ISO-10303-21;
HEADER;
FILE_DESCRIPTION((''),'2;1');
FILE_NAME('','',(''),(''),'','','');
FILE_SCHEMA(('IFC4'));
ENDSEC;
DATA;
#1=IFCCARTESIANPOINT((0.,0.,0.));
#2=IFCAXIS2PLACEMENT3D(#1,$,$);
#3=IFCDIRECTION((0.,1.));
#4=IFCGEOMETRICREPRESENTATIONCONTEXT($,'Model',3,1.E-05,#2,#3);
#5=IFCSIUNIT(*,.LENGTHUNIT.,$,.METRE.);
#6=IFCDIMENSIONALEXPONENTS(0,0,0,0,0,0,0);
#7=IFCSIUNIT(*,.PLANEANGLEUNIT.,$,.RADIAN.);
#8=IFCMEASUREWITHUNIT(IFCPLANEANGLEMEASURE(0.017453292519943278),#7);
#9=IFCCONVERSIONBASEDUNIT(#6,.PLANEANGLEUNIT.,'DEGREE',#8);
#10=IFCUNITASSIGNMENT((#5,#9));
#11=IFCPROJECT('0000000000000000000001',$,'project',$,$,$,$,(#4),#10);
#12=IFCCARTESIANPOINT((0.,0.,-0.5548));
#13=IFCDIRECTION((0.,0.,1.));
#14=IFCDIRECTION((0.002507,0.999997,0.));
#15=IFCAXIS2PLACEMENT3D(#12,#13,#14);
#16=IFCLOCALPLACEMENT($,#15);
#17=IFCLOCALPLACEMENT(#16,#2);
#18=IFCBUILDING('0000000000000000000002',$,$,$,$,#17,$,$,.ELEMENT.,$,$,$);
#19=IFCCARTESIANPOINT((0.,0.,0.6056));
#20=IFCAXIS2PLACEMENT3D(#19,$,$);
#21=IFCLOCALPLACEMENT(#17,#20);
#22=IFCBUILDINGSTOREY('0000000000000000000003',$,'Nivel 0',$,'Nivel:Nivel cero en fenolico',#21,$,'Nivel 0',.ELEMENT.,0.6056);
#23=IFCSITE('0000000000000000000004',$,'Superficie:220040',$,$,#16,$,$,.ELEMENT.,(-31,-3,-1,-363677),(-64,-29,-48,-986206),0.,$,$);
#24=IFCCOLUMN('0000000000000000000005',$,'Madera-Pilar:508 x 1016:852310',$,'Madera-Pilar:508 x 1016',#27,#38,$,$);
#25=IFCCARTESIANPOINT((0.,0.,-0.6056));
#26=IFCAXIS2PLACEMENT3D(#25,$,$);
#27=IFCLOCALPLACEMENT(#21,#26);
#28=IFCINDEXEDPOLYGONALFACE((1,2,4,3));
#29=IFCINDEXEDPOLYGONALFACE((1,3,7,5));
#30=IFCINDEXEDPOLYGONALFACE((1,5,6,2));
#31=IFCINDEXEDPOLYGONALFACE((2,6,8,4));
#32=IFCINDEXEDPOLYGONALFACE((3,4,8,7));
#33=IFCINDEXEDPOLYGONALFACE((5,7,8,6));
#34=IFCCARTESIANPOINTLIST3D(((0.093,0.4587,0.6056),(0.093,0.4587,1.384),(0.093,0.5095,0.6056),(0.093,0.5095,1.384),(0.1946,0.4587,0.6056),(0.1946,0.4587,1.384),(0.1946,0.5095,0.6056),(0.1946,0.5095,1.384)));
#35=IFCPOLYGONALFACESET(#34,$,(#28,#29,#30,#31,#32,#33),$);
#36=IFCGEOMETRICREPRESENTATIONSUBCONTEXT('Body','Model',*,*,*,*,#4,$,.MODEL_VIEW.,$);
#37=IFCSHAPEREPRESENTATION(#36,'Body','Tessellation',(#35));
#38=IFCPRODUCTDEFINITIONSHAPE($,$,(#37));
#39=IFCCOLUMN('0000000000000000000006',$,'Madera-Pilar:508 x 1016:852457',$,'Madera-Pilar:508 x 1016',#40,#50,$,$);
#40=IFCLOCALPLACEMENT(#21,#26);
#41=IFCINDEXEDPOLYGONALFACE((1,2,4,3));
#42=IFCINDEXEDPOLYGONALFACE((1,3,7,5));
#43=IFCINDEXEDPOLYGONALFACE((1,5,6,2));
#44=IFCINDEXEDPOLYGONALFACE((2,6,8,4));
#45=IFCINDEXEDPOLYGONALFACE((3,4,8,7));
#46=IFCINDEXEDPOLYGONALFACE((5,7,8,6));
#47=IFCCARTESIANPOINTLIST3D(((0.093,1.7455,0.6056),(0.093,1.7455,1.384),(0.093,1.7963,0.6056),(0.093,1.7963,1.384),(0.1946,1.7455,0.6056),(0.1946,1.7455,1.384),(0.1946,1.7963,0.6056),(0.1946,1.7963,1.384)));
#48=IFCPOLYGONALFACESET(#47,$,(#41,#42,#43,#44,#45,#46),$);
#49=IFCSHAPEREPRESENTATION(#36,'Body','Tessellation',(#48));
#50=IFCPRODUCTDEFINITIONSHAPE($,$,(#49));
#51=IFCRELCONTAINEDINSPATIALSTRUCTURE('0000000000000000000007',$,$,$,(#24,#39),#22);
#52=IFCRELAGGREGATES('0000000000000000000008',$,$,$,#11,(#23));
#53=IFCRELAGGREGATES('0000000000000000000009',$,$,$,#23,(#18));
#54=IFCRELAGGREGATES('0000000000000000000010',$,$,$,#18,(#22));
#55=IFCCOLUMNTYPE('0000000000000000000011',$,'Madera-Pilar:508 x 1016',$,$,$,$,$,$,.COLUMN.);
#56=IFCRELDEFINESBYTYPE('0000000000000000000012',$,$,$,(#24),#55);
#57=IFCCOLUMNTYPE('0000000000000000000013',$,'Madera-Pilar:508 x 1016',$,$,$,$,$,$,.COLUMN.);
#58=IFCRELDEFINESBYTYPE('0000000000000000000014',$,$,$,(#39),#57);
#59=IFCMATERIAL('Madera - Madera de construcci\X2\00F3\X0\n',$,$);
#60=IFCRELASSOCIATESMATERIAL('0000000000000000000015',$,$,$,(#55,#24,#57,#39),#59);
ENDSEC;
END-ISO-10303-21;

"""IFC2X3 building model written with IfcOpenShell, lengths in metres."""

from ifc_helpers import new_model, entity, si_unit, converted_unit, direction, frame, frame_2d, origin, place, context, subcontext, project, spatial, rectangle, extrude, source, transform, mapped, material, type_object, type_shapes, element, save


model = new_model("IFC2X3")

# Units and contexts
model_context = context("Model", 3, precision=1e-05, world=origin(), true_north=direction((0.0, 1.0)))
body_context = subcontext(model_context, "Body", "Model", "MODEL_VIEW")
ifc_project = project(units=[si_unit("LENGTHUNIT", "METRE"), converted_unit("PLANEANGLEUNIT", "DEGREE", entity("IfcPlaneAngleMeasure", 0.017453292519943278), si_unit("PLANEANGLEUNIT", "RADIAN"), dimensions=[0, 0, 0, 0, 0, 0, 0])], contexts=[model_context])

# Site, building, storey
site_placement = place(None, frame((0.0, 0.0, -0.5548), z_axis=(0.0, 0.0, 1.0), x_axis=(0.002507, 0.999997, 0.0)))
site = spatial("IfcSite", under=ifc_project, at=site_placement, Name="Superficie:220040", CompositionType="ELEMENT", RefLatitude=(-31, -3, -1, -363677), RefLongitude=(-64, -29, -48, -986206), RefElevation=0.0)
building_placement = place(site_placement, origin())
building = spatial("IfcBuilding", under=site, at=building_placement, CompositionType="ELEMENT")
storey_placement = place(building_placement, frame((0.0, 0.0, 0.6056)))
storey = spatial("IfcBuildingStorey", under=building, at=storey_placement, Name="Nivel 0", ObjectType="Nivel:Nivel cero en fenolico", LongName="Nivel 0", CompositionType="ELEMENT", Elevation=0.6056)

# Columns
ifc_material = material(Name="Madera - Madera de construcción")
column_type_1 = type_object("IfcColumnType", Name="Madera-Pilar:508 x 1016", PredefinedType="COLUMN", material=ifc_material)
shared_shape_1 = source(origin(), body_context, "Body", "SweptSolid", [
    extrude(rectangle(XDim=0.1016, YDim=0.0508, at=frame_2d((0.0, 0.0), x_axis=(1.0, 0.0))), frame((0.1438, 0.4841, 0.6056), z_axis=(0.0, 0.0, 1.0), x_axis=(-1.0, 0.0, 0.0)), (0.0, 0.0, 1.0), 0.7784),
])
type_shapes(column_type_1, [shared_shape_1])
column_1_placement = place(storey_placement, frame((0.0, 0.0, -0.6056)))
element("IfcColumn", 1, at=column_1_placement, inside=storey, type_object=column_type_1, material=ifc_material, Name="Madera-Pilar:508 x 1016:852310", ObjectType="Madera-Pilar:508 x 1016", context=body_context, shape_type="MappedRepresentation", body=[
    mapped(shared_shape_1, transform((0.0, 0.0, 0.0), scale=1.0)),
])
column_type_2 = type_object("IfcColumnType", Name="Madera-Pilar:508 x 1016", PredefinedType="COLUMN", material=ifc_material)
shared_shape_2 = source(origin(), body_context, "Body", "SweptSolid", [
    extrude(rectangle(XDim=0.1016, YDim=0.0508, at=frame_2d((0.0, 0.0), x_axis=(1.0, 0.0))), frame((0.1438, 1.7709, 0.6056), z_axis=(0.0, 0.0, 1.0), x_axis=(-1.0, 0.0, 0.0)), (0.0, 0.0, 1.0), 0.7784),
])
type_shapes(column_type_2, [shared_shape_2])
column_2_placement = place(storey_placement, frame((0.0, 0.0, -0.6056)))
element("IfcColumn", 2, at=column_2_placement, inside=storey, type_object=column_type_2, material=ifc_material, Name="Madera-Pilar:508 x 1016:852457", ObjectType="Madera-Pilar:508 x 1016", context=body_context, shape_type="MappedRepresentation", body=[
    mapped(shared_shape_2, transform((0.0, 0.0, 0.0), scale=1.0)),
])

save(model, "model.ifc")
